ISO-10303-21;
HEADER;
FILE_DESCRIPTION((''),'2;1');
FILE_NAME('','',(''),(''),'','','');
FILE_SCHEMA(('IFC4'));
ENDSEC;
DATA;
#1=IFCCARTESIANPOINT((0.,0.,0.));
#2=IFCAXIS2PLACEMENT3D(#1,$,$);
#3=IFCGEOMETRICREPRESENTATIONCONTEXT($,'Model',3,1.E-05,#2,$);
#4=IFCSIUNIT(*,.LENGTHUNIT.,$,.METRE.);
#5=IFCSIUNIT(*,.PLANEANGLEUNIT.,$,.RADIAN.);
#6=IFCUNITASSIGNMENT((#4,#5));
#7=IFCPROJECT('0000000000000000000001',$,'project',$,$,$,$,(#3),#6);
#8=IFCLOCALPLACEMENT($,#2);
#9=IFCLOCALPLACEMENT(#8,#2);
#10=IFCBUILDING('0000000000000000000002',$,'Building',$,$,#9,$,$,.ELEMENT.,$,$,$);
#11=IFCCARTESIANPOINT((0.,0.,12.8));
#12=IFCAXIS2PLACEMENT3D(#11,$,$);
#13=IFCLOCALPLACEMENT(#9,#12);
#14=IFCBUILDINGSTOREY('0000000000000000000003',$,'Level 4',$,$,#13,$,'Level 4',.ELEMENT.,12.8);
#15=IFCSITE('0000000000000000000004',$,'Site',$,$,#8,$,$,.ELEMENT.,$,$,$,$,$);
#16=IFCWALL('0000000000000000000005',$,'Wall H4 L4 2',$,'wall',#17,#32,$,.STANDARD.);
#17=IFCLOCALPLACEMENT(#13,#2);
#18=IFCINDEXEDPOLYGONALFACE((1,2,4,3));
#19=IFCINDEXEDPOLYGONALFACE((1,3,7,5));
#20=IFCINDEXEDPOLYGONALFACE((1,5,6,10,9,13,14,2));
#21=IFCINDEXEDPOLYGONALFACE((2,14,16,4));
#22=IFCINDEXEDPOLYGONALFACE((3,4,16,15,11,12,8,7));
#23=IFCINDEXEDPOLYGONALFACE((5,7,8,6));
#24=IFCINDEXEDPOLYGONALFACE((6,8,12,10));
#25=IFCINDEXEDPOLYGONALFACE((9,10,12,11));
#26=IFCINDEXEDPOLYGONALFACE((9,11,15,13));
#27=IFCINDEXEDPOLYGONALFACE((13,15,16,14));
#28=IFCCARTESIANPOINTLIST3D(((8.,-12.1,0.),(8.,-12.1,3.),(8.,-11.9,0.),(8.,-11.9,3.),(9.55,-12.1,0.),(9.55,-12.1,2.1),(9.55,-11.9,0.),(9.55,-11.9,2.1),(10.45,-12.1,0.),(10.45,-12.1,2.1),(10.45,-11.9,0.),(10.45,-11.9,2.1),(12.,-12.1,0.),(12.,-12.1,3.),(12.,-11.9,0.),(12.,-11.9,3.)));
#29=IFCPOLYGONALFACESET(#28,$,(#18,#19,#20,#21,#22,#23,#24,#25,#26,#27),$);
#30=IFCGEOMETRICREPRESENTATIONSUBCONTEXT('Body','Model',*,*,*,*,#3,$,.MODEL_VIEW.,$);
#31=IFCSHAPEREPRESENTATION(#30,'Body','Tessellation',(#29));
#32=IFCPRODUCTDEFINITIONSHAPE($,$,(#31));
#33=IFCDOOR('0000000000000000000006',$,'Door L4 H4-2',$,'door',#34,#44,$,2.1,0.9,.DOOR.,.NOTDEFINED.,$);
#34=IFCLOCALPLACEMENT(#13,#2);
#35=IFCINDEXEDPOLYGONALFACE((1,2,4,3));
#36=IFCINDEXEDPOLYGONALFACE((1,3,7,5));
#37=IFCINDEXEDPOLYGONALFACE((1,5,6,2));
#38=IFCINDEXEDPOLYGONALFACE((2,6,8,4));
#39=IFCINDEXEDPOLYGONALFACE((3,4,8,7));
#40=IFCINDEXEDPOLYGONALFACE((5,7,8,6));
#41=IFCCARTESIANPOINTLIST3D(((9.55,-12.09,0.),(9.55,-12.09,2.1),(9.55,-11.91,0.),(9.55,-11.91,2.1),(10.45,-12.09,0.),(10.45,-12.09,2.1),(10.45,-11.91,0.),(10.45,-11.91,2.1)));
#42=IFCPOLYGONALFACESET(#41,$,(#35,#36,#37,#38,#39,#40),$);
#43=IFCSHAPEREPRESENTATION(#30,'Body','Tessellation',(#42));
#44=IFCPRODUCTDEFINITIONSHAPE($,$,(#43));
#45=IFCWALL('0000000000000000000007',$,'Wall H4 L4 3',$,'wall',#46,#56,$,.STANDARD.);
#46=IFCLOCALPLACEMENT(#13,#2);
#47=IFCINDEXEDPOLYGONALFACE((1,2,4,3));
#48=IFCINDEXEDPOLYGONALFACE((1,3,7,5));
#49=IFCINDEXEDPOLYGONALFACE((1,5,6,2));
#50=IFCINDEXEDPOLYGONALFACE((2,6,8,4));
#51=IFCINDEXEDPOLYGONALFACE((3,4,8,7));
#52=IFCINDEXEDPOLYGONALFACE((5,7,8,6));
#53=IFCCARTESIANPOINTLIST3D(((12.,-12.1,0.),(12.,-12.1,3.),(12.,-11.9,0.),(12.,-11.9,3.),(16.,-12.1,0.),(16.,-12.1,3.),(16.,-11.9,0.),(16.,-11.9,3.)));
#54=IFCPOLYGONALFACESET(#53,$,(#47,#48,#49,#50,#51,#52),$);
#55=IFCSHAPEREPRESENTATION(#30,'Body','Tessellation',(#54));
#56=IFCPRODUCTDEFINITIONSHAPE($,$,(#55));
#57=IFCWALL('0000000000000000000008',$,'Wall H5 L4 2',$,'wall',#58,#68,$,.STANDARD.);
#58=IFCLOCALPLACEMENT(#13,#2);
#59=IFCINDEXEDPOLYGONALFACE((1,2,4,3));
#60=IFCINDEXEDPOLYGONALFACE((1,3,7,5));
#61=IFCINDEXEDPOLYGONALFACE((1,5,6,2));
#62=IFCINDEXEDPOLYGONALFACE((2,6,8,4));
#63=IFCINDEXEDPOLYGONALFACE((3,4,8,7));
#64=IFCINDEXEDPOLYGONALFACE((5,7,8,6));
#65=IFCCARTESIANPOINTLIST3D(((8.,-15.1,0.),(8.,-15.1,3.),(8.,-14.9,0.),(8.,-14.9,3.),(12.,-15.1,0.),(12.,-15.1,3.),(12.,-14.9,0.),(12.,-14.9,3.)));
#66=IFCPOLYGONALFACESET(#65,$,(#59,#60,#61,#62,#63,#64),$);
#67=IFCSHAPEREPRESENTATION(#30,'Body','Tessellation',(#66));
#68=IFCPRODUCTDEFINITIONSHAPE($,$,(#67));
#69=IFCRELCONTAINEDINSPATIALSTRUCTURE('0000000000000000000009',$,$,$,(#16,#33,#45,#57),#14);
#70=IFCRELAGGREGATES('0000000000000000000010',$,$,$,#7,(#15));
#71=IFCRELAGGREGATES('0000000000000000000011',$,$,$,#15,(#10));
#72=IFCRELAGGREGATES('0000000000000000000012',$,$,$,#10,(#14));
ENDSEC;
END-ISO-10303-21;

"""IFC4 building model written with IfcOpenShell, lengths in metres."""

from ifc_helpers import new_model, si_unit, frame, frame_2d, origin, origin_2d, place, context, subcontext, project, spatial, rectangle, extrude, element, fill, save


model = new_model("IFC4")

# Units and contexts
model_context = context("Model", 3, precision=1e-05, world=origin())
body_context = subcontext(model_context, "Body", "Model", "MODEL_VIEW")
ifc_project = project(units=[si_unit("LENGTHUNIT", "METRE"), si_unit("PLANEANGLEUNIT", "RADIAN")], contexts=[model_context])

# Site, building, storey
site_placement = place(None, origin())
site = spatial("IfcSite", under=ifc_project, at=site_placement, Name="Site", CompositionType="ELEMENT")
building_placement = place(site_placement, origin())
building = spatial("IfcBuilding", under=site, at=building_placement, Name="Building", CompositionType="ELEMENT")
storey_placement = place(building_placement, frame((0.0, 0.0, 12.8)))
storey = spatial("IfcBuildingStorey", under=building, at=storey_placement, Name="Level 4", LongName="Level 4", CompositionType="ELEMENT", Elevation=12.8)

# Wall, opening, door
wall_1_placement = place(storey_placement, frame((8.0, -12.0, 0.0), z_axis=(0.0, 0.0, 1.0), x_axis=(1.0, 0.0, 0.0)))
wall_1 = element("IfcWall", 1, at=wall_1_placement, inside=storey, Name="Wall H4 L4 2", ObjectType="wall", PredefinedType="STANDARD", context=body_context, shape_type="SweptSolid", body=[
    extrude(rectangle(XDim=4.0, YDim=0.2, at=frame_2d((2.0, 0.0))), origin(), (0.0, 0.0, 1.0), 3.0),
])
opening_1_placement = place(storey_placement, frame((10.0, -12.0, 0.0), z_axis=(0.0, 0.0, 1.0), x_axis=(1.0, 0.0, 0.0)))
opening_1 = element("IfcOpeningElement", 2, at=opening_1_placement, cuts=wall_1, ObjectType="Opening", PredefinedType="OPENING", context=body_context, shape_type="SweptSolid", body=[
    extrude(rectangle(XDim=0.9, YDim=0.22, at=origin_2d()), origin(), (0.0, 0.0, 1.0), 2.1),
])
door_1_placement = place(storey_placement, frame((10.0, -12.0, 0.0), z_axis=(0.0, 0.0, 1.0), x_axis=(1.0, 0.0, 0.0)))
door_1 = element("IfcDoor", 3, at=door_1_placement, inside=storey, Name="Door L4 H4-2", ObjectType="door", OperationType="NOTDEFINED", OverallHeight=2.1, OverallWidth=0.9, PredefinedType="DOOR", context=body_context, shape_type="SweptSolid", body=[
    extrude(rectangle(XDim=0.9, YDim=0.18, at=origin_2d()), origin(), (0.0, 0.0, 1.0), 2.1),
])
fill(opening_1, door_1)

# Walls
for number, where, z_axis, x_axis, name in (
    (4, (12.0, -12.0, 0.0), (0.0, 0.0, 1.0), (1.0, 0.0, 0.0), "Wall H4 L4 3"),
    (5, (8.0, -15.0, 0.0), (0.0, 0.0, 1.0), (1.0, 0.0, 0.0), "Wall H5 L4 2"),
):
    element("IfcWall", number, at=place(storey_placement, frame(where, z_axis=z_axis, x_axis=x_axis)), inside=storey, Name=name, ObjectType="wall", PredefinedType="STANDARD", context=body_context, shape_type="SweptSolid", body=[
        extrude(rectangle(XDim=4.0, YDim=0.2, at=frame_2d((2.0, 0.0))), origin(), (0.0, 0.0, 1.0), 3.0),
    ])

save(model, "model.ifc")
